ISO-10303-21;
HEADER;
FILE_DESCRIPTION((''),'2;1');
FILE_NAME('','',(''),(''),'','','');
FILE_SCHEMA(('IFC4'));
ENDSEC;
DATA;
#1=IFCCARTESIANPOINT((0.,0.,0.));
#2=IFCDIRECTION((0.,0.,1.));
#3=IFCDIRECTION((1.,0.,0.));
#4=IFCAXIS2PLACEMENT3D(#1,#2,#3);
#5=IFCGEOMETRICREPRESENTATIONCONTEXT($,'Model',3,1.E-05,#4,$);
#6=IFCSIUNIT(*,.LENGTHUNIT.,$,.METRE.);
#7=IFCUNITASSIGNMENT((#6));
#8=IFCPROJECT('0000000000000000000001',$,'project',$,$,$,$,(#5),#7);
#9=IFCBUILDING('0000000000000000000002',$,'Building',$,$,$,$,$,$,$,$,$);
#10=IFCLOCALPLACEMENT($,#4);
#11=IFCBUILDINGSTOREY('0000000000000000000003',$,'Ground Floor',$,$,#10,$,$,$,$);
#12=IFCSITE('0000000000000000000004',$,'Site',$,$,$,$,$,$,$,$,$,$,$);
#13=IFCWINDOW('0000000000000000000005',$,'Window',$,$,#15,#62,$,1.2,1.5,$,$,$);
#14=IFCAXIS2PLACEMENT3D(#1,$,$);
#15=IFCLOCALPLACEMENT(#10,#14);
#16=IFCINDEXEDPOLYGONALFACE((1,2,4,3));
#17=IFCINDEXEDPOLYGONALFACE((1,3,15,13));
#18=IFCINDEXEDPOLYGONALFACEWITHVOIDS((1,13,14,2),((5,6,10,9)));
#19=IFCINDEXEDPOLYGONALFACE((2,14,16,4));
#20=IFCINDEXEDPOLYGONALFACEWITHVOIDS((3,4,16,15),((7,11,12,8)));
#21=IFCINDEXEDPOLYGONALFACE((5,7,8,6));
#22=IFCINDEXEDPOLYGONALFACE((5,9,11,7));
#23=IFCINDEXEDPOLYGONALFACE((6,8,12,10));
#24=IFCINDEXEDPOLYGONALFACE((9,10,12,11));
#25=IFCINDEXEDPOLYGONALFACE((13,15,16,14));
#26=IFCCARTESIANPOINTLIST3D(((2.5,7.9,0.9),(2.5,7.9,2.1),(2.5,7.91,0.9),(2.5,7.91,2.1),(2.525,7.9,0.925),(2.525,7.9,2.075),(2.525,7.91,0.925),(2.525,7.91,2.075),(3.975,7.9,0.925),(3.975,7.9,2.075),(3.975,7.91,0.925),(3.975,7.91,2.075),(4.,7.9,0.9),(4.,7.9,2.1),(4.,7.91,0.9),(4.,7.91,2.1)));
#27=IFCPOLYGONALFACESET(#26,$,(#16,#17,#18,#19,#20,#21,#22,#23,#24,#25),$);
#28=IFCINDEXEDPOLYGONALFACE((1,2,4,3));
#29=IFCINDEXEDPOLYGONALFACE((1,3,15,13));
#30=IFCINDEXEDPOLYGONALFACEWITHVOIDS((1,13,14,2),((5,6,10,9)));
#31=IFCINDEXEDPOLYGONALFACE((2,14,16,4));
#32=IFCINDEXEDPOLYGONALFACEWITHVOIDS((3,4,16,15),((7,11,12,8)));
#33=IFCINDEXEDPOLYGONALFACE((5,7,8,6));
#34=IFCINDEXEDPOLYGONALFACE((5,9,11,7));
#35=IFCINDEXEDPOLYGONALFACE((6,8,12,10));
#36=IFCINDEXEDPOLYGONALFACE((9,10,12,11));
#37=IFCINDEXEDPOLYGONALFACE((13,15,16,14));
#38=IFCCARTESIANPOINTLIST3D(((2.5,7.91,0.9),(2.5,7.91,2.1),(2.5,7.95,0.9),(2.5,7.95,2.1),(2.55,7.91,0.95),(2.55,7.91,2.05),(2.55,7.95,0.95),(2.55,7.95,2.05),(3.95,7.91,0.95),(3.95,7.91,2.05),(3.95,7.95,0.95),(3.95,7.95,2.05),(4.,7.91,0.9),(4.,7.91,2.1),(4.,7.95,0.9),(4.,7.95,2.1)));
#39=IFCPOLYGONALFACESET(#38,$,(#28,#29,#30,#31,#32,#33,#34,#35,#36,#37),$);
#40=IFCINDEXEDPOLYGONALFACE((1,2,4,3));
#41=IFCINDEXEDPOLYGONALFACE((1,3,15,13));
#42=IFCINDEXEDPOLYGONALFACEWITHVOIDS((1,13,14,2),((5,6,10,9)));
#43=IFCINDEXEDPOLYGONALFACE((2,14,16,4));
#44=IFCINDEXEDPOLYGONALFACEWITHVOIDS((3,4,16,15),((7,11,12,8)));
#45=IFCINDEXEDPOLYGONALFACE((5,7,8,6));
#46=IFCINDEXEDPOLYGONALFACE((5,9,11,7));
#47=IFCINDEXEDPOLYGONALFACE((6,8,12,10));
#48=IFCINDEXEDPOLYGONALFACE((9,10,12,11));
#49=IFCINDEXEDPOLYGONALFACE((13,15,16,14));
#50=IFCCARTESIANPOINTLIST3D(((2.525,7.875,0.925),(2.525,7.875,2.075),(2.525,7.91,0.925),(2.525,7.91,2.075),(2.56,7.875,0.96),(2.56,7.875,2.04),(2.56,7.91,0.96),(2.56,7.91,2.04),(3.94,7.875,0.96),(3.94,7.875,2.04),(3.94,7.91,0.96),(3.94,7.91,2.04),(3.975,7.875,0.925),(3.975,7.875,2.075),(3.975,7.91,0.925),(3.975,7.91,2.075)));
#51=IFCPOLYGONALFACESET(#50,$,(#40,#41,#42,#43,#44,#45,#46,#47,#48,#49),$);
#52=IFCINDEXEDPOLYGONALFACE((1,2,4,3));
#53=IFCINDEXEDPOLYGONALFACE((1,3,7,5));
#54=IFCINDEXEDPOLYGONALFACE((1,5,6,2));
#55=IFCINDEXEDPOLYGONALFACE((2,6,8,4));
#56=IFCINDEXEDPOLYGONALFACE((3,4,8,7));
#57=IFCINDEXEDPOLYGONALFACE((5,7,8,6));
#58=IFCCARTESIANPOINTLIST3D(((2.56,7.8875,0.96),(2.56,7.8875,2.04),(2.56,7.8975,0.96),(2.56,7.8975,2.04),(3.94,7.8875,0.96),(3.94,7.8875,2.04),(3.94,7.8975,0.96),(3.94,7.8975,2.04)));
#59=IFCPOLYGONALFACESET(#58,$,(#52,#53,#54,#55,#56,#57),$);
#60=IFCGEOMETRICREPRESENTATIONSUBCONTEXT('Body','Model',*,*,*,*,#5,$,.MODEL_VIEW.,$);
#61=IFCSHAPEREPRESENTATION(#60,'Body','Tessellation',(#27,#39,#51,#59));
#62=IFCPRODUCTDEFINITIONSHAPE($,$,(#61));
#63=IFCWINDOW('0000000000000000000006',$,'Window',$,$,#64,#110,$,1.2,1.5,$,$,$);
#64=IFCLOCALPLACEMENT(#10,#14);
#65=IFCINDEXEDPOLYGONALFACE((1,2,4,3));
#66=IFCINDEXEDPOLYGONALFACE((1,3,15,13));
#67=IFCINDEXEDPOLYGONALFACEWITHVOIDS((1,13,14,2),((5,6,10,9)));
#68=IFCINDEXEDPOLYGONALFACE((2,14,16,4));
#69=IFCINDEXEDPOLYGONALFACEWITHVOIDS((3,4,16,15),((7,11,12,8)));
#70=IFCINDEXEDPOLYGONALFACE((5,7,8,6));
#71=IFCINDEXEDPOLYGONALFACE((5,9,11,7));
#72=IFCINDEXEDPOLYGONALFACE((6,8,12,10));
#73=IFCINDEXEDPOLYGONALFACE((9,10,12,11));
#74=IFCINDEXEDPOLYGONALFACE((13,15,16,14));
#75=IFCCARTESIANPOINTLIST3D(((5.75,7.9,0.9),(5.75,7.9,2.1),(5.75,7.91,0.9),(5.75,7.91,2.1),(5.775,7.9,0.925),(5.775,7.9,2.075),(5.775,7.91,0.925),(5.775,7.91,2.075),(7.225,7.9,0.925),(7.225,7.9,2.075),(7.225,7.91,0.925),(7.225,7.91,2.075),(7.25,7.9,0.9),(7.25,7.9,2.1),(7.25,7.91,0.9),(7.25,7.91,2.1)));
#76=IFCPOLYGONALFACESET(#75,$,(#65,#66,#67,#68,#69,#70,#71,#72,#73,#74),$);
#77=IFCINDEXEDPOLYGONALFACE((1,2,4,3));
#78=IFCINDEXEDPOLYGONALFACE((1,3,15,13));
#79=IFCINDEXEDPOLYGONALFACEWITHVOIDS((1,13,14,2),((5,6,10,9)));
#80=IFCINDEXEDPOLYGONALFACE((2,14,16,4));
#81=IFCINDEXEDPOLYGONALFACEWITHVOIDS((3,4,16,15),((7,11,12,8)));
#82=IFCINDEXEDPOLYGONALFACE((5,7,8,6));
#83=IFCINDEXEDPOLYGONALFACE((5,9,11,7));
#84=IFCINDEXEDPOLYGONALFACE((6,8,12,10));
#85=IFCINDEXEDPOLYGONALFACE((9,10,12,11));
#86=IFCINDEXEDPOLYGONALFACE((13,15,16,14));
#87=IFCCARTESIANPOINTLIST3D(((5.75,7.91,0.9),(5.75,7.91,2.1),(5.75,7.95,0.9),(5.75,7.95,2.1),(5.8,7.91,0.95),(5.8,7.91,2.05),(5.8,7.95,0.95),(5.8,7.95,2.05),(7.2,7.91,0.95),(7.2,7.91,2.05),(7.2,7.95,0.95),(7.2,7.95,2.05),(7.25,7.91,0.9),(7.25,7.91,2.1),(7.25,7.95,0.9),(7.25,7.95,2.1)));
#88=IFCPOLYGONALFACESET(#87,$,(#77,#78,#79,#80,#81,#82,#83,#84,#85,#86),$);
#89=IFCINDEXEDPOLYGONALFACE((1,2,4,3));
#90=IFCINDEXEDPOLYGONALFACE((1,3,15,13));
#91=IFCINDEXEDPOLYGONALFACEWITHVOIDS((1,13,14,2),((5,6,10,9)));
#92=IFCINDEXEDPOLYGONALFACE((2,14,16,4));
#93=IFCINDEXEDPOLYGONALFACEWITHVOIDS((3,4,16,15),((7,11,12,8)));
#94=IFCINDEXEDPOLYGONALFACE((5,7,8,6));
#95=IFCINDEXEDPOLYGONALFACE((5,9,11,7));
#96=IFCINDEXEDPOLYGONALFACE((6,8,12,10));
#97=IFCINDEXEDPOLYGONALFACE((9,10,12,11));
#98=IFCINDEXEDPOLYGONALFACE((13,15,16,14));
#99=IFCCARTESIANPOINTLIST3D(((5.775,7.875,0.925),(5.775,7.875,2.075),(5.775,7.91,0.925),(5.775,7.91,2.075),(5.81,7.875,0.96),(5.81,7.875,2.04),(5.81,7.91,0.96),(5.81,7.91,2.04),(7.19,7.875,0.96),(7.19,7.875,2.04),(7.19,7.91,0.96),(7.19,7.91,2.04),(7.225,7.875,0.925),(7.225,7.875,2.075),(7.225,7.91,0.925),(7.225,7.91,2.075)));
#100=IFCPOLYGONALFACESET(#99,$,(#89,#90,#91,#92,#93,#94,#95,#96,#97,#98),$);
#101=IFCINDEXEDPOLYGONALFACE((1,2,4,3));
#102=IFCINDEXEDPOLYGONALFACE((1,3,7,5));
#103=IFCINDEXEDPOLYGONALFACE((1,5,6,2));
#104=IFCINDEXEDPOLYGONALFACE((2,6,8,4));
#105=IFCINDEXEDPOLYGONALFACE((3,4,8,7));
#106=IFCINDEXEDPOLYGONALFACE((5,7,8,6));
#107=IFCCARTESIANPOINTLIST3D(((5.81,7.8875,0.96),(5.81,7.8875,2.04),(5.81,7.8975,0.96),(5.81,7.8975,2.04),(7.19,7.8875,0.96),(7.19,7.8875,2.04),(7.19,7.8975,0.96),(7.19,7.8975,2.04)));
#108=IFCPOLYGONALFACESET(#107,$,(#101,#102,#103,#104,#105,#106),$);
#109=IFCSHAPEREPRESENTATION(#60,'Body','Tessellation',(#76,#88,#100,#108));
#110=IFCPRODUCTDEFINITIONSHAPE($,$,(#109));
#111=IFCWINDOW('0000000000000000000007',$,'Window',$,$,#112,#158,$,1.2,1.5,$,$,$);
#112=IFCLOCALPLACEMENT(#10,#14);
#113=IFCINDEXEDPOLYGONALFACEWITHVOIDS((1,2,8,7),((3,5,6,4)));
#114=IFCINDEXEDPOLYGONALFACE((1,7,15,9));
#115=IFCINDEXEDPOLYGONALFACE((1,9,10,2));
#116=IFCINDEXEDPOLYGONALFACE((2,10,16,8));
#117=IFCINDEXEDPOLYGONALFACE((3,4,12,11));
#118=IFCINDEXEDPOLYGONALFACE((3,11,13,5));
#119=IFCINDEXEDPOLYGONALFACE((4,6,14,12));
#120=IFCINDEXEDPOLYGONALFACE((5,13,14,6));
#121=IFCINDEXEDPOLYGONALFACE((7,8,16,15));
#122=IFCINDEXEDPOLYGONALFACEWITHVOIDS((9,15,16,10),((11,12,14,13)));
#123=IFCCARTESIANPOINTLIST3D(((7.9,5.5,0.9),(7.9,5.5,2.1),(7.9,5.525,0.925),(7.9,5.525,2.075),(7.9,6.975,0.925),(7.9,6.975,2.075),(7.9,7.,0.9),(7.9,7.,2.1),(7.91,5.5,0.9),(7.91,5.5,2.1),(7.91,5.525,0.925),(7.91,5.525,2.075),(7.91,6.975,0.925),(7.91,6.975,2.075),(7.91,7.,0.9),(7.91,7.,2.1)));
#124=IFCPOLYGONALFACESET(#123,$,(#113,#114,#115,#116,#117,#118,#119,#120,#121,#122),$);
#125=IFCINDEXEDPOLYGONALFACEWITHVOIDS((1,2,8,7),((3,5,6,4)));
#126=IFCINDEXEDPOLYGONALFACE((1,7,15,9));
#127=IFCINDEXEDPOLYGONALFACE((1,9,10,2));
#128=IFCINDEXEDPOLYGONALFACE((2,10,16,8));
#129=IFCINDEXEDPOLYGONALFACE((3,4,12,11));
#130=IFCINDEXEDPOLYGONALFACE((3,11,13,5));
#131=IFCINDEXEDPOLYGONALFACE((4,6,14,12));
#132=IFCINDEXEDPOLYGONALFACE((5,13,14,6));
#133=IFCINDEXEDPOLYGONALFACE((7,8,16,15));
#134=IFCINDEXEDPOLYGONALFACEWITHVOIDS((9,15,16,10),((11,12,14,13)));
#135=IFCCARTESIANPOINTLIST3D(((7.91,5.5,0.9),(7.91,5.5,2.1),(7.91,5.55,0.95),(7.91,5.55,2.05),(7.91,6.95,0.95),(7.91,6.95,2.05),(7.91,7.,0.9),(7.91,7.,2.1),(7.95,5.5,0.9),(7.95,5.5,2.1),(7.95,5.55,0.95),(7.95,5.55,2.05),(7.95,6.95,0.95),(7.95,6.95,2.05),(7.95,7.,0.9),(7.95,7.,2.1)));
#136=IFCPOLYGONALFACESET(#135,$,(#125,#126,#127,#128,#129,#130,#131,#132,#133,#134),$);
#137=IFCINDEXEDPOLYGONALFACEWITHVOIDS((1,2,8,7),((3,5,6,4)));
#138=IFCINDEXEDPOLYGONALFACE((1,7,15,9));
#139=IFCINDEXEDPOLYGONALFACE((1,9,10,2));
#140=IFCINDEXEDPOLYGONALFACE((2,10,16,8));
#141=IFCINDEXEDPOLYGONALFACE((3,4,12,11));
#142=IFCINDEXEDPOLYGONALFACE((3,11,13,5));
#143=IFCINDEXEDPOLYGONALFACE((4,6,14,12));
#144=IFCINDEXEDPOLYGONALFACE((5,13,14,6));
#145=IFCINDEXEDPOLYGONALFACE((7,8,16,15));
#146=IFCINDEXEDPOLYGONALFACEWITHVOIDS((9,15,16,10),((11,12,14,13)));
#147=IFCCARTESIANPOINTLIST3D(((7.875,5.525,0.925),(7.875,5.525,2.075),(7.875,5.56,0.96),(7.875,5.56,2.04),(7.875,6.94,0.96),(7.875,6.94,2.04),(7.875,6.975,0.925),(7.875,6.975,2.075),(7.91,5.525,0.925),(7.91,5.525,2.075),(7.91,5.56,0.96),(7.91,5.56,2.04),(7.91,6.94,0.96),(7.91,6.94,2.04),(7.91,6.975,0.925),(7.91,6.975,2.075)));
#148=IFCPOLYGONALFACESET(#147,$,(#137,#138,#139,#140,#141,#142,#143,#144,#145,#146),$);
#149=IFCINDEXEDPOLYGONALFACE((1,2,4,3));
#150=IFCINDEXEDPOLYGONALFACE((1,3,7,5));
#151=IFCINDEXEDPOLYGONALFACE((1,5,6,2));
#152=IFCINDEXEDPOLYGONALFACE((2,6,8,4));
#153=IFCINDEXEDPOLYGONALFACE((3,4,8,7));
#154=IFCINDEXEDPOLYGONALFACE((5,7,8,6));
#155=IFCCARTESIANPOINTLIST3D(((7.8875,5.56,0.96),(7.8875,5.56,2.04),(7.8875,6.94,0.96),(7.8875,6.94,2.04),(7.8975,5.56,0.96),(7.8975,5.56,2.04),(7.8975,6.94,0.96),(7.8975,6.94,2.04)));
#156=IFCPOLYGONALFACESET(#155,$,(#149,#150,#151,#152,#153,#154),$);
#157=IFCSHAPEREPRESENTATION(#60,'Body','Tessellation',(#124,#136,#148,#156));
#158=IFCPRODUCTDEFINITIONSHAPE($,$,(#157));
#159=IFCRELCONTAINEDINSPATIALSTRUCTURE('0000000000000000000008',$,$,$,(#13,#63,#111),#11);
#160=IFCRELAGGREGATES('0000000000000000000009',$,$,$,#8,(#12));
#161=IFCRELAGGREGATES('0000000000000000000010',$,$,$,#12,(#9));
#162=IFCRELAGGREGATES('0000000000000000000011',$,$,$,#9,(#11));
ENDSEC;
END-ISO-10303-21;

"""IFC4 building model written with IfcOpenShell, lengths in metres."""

from ifc_helpers import new_model, si_unit, frame, origin_with_axes, place, context, subcontext, project, spatial, line, indexed_curve, outline, extrude, element, save


model = new_model("IFC4")

# Units and contexts
model_context = context("Model", 3, precision=1e-05, world=origin_with_axes())
body_context = subcontext(model_context, "Body", "Model", "MODEL_VIEW")
ifc_project = project(units=[si_unit("LENGTHUNIT", "METRE")], contexts=[model_context])

# Site, building, storey
site = spatial("IfcSite", under=ifc_project, Name="Site")
building = spatial("IfcBuilding", under=site, Name="Building")
storey_placement = place(None, origin_with_axes())
storey = spatial("IfcBuildingStorey", under=building, at=storey_placement, Name="Ground Floor")

# Windows
for number, where, z_axis, x_axis, name in (
    (1, (4.0, 8.0, 0.9), (0.0, 0.0, 1.0), (-1.0, 0.0, 0.0), "Window"),
    (2, (7.25, 8.0, 0.9), (0.0, 0.0, 1.0), (-1.0, 0.0, 0.0), "Window"),
    (3, (8.0, 5.5, 0.9), (0.0, 0.0, 1.0), (0.0, 1.0, 0.0), "Window"),
):
    element("IfcWindow", number, at=place(storey_placement, frame(where, z_axis=z_axis, x_axis=x_axis)), inside=storey, Name=name, OverallHeight=1.2, OverallWidth=1.5, context=body_context, shape_type="SweptSolid", body=[
        extrude(outline(indexed_curve([(0.0, 0.0), (1.5, 0.0), (1.5, 1.2), (0.0, 1.2)], segments=[line(1, 2, 3, 4, 1)]), holes=[indexed_curve([(0.025, 0.025), (1.475, 0.025), (1.475, 1.175), (0.025, 1.175)], segments=[line(1, 2, 3, 4, 1)])]), frame((0.0, 0.09, 0.0), z_axis=(0.0, -1.0, 0.0), x_axis=(1.0, 0.0, 0.0)), (0.0, 0.0, -1.0), 0.01),
        extrude(outline(indexed_curve([(0.0, 0.0), (1.5, 0.0), (1.5, 1.2), (0.0, 1.2)], segments=[line(1, 2, 3, 4, 1)]), holes=[indexed_curve([(0.05, 0.05), (1.45, 0.05), (1.45, 1.15), (0.05, 1.15)], segments=[line(1, 2, 3, 4, 1)])]), frame((0.0, 0.05, 0.0), z_axis=(0.0, -1.0, 0.0), x_axis=(1.0, 0.0, 0.0)), (0.0, 0.0, -1.0), 0.04),
        extrude(outline(indexed_curve([(0.0, 0.0), (1.45, 0.0), (1.45, 1.15), (0.0, 1.15)], segments=[line(1, 2, 3, 4, 1)]), holes=[indexed_curve([(0.035, 0.035), (1.415, 0.035), (1.415, 1.115), (0.035, 1.115)], segments=[line(1, 2, 3, 4, 1)])]), frame((0.025, 0.09, 0.025), z_axis=(0.0, -1.0, 0.0), x_axis=(1.0, 0.0, 0.0)), (0.0, 0.0, -1.0), 0.035),
        extrude(outline(indexed_curve([(0.035, 0.035), (1.415, 0.035), (1.415, 1.115), (0.035, 1.115)], segments=[line(1, 2, 3, 4, 1)])), frame((0.025, 0.1025, 0.025), z_axis=(0.0, -1.0, 0.0), x_axis=(1.0, 0.0, 0.0)), (0.0, 0.0, -1.0), 0.01),
    ])

save(model, "model.ifc")
